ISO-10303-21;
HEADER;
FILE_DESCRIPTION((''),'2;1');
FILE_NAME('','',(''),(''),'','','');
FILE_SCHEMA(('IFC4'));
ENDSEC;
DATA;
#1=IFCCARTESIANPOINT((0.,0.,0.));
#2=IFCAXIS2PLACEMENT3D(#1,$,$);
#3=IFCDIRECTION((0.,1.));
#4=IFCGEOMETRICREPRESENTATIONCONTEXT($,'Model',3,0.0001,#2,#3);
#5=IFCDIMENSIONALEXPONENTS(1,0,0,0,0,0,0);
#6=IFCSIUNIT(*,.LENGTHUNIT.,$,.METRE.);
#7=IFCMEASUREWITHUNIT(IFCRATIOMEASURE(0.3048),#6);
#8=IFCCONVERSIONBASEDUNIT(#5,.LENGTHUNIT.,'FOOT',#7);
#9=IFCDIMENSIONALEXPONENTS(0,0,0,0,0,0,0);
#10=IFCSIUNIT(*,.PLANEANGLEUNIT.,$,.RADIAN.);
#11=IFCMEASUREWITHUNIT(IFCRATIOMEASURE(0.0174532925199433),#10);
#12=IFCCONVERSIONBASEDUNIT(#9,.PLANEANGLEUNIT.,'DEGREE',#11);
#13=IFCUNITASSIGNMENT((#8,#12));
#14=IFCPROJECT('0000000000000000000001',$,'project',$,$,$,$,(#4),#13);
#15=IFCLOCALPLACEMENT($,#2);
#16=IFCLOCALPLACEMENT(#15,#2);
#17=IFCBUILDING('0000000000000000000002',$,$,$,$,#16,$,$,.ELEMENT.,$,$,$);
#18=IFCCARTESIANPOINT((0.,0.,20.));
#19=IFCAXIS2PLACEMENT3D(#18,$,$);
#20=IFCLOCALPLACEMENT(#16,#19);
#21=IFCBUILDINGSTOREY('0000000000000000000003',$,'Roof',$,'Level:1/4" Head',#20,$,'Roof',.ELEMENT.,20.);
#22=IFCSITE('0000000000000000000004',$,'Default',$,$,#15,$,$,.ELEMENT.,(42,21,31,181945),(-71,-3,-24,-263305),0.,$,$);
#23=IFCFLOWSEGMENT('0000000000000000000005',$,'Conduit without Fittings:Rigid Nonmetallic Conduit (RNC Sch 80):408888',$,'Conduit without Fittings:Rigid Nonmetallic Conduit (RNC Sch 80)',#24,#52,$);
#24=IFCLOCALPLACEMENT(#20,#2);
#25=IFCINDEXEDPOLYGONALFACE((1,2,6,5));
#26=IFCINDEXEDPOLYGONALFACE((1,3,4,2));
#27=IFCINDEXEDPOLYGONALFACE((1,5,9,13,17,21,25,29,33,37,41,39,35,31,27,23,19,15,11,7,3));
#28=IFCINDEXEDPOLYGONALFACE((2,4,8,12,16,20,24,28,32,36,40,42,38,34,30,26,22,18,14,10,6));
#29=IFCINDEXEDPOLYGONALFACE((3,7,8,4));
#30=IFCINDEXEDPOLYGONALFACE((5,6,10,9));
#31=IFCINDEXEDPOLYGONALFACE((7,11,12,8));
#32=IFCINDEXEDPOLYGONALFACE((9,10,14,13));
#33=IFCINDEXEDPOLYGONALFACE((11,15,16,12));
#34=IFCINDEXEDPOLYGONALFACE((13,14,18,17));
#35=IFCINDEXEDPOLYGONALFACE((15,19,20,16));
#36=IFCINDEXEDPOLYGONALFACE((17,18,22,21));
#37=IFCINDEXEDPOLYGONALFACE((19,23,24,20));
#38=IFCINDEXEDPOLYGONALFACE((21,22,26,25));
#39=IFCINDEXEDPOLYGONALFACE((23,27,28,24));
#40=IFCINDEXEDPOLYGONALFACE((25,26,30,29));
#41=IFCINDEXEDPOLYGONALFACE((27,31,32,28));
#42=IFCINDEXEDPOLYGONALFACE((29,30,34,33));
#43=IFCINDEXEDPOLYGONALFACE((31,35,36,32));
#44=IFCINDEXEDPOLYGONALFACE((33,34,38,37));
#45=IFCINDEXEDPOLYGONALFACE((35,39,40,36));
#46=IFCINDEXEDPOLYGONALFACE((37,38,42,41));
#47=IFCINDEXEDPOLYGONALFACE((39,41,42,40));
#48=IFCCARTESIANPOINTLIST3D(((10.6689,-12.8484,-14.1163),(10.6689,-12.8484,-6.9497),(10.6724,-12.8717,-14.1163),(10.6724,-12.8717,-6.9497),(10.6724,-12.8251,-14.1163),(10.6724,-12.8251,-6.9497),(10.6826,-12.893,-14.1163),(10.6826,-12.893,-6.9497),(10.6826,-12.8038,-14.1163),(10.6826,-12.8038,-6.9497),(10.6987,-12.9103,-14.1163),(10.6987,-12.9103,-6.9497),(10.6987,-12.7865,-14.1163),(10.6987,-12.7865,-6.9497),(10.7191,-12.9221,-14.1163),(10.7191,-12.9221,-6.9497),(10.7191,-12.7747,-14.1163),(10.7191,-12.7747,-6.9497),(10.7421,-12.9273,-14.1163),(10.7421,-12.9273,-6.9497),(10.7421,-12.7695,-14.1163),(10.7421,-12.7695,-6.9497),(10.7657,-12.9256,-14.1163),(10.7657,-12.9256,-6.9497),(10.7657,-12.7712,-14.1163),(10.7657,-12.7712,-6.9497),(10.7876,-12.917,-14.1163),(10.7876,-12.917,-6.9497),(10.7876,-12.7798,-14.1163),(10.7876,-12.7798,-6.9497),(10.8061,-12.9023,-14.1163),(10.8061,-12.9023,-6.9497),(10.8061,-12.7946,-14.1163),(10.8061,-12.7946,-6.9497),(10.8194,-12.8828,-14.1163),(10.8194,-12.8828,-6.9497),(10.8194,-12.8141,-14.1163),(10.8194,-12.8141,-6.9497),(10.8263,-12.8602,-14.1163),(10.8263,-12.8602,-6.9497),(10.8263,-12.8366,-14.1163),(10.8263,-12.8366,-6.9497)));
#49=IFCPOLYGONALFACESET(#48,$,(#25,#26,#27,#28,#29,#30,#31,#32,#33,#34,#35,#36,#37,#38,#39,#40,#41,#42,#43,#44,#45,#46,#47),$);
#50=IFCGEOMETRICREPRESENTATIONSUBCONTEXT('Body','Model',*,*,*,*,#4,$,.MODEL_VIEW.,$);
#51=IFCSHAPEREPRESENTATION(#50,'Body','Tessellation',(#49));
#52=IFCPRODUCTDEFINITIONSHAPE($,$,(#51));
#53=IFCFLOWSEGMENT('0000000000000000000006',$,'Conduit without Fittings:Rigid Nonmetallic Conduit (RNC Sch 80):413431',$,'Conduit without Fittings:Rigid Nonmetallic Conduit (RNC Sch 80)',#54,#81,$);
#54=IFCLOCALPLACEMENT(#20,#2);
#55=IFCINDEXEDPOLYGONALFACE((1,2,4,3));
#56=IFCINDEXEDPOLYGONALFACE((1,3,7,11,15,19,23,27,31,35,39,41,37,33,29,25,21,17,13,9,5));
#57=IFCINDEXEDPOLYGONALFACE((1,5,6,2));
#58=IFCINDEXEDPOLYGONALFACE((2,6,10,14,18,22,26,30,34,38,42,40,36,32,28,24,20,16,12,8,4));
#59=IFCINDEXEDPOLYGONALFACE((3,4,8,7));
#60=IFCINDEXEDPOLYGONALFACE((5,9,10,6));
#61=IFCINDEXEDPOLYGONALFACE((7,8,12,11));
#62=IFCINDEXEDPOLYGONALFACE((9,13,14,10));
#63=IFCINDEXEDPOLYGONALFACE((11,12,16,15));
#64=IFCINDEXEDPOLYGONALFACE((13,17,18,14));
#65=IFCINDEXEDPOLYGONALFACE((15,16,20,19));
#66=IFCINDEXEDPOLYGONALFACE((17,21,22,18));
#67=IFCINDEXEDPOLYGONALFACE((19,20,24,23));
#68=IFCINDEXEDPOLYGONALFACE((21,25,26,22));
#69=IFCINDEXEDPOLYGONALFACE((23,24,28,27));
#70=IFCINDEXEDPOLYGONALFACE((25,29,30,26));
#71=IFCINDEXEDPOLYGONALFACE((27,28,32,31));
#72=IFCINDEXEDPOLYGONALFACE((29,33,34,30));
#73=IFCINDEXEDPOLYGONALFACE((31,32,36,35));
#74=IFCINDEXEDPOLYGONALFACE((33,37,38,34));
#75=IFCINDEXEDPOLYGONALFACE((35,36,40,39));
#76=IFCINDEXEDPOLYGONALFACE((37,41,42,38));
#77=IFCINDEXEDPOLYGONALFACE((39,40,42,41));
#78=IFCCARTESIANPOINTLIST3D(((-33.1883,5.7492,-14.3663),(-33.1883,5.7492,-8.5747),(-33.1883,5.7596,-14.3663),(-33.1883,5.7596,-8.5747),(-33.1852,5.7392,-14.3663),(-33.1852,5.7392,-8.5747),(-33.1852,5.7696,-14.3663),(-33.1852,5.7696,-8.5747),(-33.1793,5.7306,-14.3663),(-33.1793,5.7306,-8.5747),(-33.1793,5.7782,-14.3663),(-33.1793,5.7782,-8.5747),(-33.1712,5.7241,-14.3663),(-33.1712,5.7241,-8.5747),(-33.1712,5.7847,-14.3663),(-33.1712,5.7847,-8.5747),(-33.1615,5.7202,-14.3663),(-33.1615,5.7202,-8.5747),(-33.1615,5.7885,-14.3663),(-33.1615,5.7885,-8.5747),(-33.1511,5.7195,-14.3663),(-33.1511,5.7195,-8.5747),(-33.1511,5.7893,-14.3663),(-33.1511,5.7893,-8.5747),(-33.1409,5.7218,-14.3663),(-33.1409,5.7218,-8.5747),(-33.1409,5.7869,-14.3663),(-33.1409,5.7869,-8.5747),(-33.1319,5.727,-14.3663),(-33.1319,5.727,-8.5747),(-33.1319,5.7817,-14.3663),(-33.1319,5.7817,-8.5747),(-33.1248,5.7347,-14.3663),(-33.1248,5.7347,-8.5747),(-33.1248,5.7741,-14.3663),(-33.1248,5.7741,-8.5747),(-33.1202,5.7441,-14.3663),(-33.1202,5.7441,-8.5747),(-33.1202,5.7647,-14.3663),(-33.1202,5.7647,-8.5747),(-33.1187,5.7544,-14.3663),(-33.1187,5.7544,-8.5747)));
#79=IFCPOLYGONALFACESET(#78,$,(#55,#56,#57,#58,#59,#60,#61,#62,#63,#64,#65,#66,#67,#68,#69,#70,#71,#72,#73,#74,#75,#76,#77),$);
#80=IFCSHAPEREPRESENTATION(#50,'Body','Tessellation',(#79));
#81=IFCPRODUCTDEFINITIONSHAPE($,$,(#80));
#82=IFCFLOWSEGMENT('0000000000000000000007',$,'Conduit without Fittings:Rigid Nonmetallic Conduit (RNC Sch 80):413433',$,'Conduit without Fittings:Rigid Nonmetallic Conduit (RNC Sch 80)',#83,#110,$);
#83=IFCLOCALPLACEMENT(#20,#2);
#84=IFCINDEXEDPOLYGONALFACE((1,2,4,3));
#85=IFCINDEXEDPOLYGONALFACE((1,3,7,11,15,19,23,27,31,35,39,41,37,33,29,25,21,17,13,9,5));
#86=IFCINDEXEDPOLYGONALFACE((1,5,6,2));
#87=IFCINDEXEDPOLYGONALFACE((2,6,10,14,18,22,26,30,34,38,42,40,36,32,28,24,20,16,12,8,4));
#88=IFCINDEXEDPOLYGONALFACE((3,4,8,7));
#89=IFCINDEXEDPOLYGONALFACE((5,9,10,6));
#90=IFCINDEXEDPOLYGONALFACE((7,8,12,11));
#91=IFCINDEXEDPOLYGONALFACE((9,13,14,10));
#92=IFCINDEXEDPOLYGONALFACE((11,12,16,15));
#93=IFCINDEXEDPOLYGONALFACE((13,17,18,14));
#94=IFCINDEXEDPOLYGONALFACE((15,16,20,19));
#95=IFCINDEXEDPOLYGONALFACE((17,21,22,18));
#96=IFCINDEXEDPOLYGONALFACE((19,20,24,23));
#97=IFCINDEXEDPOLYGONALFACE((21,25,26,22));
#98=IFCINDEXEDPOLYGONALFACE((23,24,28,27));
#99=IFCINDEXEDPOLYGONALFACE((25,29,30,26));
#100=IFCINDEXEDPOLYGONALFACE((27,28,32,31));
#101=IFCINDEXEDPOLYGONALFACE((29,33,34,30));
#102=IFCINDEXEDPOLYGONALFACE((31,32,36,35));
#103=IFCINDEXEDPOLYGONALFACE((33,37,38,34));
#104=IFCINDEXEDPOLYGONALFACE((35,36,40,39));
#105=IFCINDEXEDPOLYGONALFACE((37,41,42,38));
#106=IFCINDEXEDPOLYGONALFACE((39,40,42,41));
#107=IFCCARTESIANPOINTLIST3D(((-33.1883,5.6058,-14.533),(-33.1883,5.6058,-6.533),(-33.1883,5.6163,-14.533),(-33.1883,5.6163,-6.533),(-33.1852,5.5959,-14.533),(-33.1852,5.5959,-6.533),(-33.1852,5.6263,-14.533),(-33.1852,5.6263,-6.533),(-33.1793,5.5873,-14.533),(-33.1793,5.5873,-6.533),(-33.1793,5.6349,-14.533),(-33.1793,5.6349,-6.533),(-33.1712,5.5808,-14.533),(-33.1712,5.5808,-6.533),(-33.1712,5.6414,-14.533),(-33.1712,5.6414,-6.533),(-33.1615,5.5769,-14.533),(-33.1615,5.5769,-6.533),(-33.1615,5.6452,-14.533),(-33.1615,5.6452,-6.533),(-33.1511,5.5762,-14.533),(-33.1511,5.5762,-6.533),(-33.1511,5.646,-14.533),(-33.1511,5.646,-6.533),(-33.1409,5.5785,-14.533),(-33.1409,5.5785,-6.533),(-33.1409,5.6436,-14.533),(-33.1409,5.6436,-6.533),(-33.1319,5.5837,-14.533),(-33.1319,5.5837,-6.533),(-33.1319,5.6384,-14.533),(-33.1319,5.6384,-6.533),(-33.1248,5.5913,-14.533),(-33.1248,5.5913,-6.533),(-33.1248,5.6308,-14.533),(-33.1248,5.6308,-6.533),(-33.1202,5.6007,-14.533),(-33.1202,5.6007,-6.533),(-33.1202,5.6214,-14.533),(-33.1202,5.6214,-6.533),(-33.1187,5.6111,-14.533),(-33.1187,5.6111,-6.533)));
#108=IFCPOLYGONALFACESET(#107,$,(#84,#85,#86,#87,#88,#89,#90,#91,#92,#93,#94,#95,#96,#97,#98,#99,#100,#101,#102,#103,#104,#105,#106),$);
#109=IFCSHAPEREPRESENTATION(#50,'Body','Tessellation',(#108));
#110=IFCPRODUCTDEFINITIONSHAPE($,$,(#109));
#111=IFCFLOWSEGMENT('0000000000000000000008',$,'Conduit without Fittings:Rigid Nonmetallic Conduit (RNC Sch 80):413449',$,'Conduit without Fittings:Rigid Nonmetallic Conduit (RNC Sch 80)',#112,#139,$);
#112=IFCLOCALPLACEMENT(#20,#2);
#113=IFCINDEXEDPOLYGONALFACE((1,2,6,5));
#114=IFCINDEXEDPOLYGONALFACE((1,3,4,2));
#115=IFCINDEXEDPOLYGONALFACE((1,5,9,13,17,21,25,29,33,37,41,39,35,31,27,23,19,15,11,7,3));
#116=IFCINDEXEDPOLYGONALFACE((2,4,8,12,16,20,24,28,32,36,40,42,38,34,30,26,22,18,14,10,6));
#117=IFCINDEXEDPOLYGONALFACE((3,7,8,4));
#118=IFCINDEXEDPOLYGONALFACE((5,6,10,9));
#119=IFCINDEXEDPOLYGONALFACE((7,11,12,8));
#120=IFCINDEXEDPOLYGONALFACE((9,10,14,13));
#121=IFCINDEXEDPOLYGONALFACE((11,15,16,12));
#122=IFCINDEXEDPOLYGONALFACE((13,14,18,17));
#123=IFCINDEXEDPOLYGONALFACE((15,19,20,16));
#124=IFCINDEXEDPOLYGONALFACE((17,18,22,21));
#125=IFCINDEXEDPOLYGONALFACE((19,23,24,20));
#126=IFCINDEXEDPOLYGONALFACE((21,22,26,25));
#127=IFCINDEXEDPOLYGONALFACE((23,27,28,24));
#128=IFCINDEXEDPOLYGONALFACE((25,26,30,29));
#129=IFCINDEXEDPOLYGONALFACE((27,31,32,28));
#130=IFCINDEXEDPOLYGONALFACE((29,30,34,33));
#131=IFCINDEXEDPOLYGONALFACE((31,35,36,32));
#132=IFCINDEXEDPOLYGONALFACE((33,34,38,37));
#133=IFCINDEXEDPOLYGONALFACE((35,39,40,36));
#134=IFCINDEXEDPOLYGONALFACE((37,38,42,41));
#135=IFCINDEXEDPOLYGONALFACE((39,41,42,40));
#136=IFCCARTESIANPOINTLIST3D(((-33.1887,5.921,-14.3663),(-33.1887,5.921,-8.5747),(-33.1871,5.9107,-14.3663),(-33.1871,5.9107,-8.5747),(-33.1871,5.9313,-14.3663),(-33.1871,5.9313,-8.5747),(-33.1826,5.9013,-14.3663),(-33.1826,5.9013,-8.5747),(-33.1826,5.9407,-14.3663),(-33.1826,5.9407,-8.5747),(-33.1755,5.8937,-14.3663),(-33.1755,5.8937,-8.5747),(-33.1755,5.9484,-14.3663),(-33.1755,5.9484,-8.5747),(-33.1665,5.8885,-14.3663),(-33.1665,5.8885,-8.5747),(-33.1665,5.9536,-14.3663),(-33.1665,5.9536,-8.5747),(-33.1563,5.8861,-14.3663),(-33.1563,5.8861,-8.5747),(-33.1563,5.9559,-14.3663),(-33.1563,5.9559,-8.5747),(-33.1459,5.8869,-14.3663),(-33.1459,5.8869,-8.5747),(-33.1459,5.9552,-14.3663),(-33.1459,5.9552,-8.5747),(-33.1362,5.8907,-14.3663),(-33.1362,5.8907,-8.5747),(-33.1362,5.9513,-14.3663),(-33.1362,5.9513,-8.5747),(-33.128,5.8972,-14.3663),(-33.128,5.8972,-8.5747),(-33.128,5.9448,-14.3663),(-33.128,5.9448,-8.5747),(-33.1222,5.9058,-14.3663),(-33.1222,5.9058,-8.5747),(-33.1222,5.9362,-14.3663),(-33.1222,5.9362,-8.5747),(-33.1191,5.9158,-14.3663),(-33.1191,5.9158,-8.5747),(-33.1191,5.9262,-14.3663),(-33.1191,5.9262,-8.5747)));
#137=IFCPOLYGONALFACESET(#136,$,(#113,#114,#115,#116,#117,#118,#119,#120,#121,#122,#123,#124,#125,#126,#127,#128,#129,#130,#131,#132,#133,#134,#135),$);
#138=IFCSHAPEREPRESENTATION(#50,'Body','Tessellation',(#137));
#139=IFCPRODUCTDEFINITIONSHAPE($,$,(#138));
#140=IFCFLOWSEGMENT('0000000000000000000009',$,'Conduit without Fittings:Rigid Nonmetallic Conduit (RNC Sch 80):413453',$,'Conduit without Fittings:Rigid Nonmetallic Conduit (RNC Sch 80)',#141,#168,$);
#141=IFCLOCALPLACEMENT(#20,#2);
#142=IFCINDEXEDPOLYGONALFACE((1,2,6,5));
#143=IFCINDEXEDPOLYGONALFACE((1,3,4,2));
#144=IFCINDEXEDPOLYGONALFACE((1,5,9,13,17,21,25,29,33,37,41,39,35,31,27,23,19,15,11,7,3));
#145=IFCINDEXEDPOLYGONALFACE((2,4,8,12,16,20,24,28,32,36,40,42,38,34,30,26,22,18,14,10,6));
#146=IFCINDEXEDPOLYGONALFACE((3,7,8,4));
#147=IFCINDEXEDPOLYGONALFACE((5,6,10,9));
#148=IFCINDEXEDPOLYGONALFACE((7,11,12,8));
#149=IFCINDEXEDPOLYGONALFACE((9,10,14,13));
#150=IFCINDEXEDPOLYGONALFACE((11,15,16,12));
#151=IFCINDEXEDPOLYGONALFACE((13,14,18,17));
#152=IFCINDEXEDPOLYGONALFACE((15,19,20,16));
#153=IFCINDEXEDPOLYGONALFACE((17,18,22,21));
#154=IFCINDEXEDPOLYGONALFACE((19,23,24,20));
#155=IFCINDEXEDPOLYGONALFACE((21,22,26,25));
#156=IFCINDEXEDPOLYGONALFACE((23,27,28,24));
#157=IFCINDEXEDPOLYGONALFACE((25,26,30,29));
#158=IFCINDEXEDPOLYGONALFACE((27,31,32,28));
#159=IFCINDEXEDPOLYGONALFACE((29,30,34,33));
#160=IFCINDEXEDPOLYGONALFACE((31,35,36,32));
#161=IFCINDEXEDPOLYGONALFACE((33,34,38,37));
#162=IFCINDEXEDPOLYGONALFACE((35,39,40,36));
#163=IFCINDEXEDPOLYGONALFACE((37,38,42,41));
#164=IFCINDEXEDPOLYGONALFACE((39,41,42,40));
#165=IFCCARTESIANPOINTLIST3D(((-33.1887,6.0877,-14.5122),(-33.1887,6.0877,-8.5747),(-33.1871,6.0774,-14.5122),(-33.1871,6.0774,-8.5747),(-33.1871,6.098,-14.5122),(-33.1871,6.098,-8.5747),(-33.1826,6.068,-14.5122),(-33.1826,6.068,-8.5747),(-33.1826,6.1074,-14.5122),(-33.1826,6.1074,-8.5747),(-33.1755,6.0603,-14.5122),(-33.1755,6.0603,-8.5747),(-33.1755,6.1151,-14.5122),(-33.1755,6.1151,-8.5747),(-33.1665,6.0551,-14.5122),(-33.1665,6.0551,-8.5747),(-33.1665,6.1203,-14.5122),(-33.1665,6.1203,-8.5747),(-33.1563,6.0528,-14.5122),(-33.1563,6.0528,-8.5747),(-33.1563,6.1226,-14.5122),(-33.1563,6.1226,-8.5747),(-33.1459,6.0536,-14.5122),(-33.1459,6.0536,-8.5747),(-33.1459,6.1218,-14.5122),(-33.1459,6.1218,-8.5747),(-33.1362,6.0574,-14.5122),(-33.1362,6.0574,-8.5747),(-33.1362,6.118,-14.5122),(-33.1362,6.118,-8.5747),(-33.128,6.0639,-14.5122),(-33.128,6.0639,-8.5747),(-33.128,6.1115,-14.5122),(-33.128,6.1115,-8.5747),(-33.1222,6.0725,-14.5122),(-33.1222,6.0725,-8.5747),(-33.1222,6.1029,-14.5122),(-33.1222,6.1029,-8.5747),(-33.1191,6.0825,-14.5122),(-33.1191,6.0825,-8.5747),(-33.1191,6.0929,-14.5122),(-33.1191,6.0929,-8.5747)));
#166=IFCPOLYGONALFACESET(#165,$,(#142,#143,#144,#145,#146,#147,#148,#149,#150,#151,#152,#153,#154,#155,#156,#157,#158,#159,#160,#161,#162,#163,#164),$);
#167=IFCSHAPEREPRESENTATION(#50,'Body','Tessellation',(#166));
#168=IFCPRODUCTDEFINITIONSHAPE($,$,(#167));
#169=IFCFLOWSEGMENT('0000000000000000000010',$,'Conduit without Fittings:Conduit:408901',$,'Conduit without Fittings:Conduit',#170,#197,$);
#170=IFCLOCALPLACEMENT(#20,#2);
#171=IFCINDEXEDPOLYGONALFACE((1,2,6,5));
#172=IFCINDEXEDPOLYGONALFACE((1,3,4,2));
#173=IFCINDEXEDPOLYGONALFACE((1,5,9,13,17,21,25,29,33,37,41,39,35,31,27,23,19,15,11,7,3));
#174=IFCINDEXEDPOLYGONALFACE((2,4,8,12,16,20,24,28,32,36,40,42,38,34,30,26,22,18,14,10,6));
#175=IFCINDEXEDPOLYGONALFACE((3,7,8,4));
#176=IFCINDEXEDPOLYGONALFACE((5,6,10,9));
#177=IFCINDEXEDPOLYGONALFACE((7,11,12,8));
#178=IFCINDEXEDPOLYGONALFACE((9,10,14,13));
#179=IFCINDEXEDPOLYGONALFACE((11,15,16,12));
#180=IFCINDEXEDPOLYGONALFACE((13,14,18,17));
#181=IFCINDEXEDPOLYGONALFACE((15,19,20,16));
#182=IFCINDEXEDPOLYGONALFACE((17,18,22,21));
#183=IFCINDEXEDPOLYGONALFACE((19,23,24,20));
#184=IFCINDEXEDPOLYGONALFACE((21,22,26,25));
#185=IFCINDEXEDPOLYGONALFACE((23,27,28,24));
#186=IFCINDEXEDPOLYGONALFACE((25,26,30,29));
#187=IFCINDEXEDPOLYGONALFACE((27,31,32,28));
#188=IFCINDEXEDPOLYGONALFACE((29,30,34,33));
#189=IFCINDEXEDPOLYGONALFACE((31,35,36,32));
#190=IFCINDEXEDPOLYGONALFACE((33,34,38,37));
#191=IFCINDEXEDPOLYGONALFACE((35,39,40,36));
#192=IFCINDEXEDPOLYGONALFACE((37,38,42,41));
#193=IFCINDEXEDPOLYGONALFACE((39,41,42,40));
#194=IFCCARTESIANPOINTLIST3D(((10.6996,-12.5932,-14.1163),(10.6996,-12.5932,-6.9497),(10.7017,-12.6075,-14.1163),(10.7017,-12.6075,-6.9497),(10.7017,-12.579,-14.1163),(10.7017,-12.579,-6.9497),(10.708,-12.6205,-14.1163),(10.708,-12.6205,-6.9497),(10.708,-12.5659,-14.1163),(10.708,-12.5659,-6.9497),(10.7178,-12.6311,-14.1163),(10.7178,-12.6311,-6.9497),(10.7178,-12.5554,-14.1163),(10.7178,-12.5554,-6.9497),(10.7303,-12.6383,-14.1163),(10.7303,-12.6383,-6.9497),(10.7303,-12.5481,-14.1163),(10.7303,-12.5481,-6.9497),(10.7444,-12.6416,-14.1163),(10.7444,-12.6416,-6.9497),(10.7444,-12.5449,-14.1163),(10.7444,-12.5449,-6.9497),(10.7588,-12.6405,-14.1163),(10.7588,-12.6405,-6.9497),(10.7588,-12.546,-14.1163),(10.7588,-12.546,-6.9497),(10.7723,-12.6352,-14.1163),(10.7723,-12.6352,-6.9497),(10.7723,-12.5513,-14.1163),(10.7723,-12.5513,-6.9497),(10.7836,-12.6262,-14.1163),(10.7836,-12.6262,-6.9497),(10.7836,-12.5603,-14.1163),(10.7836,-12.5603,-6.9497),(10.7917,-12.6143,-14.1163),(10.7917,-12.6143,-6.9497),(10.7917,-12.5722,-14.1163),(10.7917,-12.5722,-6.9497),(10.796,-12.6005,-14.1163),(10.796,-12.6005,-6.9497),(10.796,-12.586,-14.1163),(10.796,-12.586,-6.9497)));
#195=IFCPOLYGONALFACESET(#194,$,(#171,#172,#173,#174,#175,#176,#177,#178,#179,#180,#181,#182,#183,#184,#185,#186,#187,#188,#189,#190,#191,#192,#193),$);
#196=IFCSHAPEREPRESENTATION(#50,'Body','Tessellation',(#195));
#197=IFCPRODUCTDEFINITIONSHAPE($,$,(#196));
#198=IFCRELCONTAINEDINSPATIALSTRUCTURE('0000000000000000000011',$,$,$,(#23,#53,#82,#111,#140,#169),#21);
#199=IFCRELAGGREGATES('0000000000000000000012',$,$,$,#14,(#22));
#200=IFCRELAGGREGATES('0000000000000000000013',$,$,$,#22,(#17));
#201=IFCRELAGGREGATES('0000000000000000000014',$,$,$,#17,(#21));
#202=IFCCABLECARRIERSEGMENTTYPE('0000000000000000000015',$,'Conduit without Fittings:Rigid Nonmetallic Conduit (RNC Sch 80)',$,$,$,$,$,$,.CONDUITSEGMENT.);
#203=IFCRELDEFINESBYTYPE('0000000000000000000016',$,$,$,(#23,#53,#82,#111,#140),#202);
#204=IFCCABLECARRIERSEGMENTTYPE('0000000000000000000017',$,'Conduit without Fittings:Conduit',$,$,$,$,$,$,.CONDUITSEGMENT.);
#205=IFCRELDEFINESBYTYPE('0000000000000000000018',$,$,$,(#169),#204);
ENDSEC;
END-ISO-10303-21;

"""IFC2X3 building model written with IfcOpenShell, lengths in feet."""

from ifc_helpers import new_model, entity, si_unit, converted_unit, direction, frame, frame_2d, origin, origin_2d_with_axis, place, context, subcontext, project, spatial, circle, extrude, type_object, element, save


model = new_model("IFC2X3")

# Units and contexts
model_context = context("Model", 3, precision=0.0001, world=origin(), true_north=direction((0.0, 1.0)))
body_context = subcontext(model_context, "Body", "Model", "MODEL_VIEW")
ifc_project = project(units=[converted_unit("LENGTHUNIT", "FOOT", entity("IfcRatioMeasure", 0.3048), si_unit("LENGTHUNIT", "METRE"), dimensions=[1, 0, 0, 0, 0, 0, 0]), converted_unit("PLANEANGLEUNIT", "DEGREE", entity("IfcRatioMeasure", 0.0174532925199433), si_unit("PLANEANGLEUNIT", "RADIAN"), dimensions=[0, 0, 0, 0, 0, 0, 0])], contexts=[model_context])

# Site, building, storey
site_placement = place(None, origin())
site = spatial("IfcSite", under=ifc_project, at=site_placement, Name="Default", CompositionType="ELEMENT", RefLatitude=(42, 21, 31, 181945), RefLongitude=(-71, -3, -24, -263305), RefElevation=0.0)
building_placement = place(site_placement, origin())
building = spatial("IfcBuilding", under=site, at=building_placement, CompositionType="ELEMENT")
storey_placement = place(building_placement, frame((0.0, 0.0, 20.0)))
storey = spatial("IfcBuildingStorey", under=building, at=storey_placement, Name="Roof", ObjectType="Level:1/4\" Head", LongName="Roof", CompositionType="ELEMENT", Elevation=20.0)

# Flow segments
cable_carrier_segment_type_1 = type_object("IfcCableCarrierSegmentType", Name="Conduit without Fittings:Rigid Nonmetallic Conduit (RNC Sch 80)", PredefinedType="CONDUITSEGMENT")
flow_segment_1_placement = place(storey_placement, origin())
element("IfcFlowSegment", 1, at=flow_segment_1_placement, inside=storey, type_object=cable_carrier_segment_type_1, Name="Conduit without Fittings:Rigid Nonmetallic Conduit (RNC Sch 80):408888", ObjectType="Conduit without Fittings:Rigid Nonmetallic Conduit (RNC Sch 80)", context=body_context, shape_type="SweptSolid", body=[
    extrude(circle(Radius=0.0792, at=origin_2d_with_axis()), frame((10.748, -12.8484, -14.1163), z_axis=(0.0, 0.0, 1.0), x_axis=(-1.0, 0.0, 0.0)), (0.0, 0.0, 1.0), 7.1667),
])
flow_segment_2_placement = place(storey_placement, origin())
element("IfcFlowSegment", 2, at=flow_segment_2_placement, inside=storey, type_object=cable_carrier_segment_type_1, Name="Conduit without Fittings:Rigid Nonmetallic Conduit (RNC Sch 80):413431", ObjectType="Conduit without Fittings:Rigid Nonmetallic Conduit (RNC Sch 80)", context=body_context, shape_type="SweptSolid", body=[
    extrude(circle(Radius=0.035, at=frame_2d((0.0, 0.0), x_axis=(1.0, 0.0))), frame((-33.1537, 5.7544, -14.3663)), (0.0, 0.0, 1.0), 5.7917),
])
flow_segment_3_placement = place(storey_placement, origin())
element("IfcFlowSegment", 3, at=flow_segment_3_placement, inside=storey, type_object=cable_carrier_segment_type_1, Name="Conduit without Fittings:Rigid Nonmetallic Conduit (RNC Sch 80):413433", ObjectType="Conduit without Fittings:Rigid Nonmetallic Conduit (RNC Sch 80)", context=body_context, shape_type="SweptSolid", body=[
    extrude(circle(Radius=0.035, at=frame_2d((0.0, 0.0), x_axis=(1.0, 0.0))), frame((-33.1537, 5.6111, -14.533)), (0.0, 0.0, 1.0), 8.0),
])
flow_segment_4_placement = place(storey_placement, origin())
element("IfcFlowSegment", 4, at=flow_segment_4_placement, inside=storey, type_object=cable_carrier_segment_type_1, Name="Conduit without Fittings:Rigid Nonmetallic Conduit (RNC Sch 80):413449", ObjectType="Conduit without Fittings:Rigid Nonmetallic Conduit (RNC Sch 80)", context=body_context, shape_type="SweptSolid", body=[
    extrude(circle(Radius=0.035, at=origin_2d_with_axis()), frame((-33.1537, 5.921, -14.3663), z_axis=(0.0, 0.0, 1.0), x_axis=(-1.0, 0.0, 0.0)), (0.0, 0.0, 1.0), 5.7917),
])
flow_segment_5_placement = place(storey_placement, origin())
element("IfcFlowSegment", 5, at=flow_segment_5_placement, inside=storey, type_object=cable_carrier_segment_type_1, Name="Conduit without Fittings:Rigid Nonmetallic Conduit (RNC Sch 80):413453", ObjectType="Conduit without Fittings:Rigid Nonmetallic Conduit (RNC Sch 80)", context=body_context, shape_type="SweptSolid", body=[
    extrude(circle(Radius=0.035, at=origin_2d_with_axis()), frame((-33.1537, 6.0877, -14.5122), z_axis=(0.0, 0.0, 1.0), x_axis=(-1.0, 0.0, 0.0)), (0.0, 0.0, 1.0), 5.9375),
])
cable_carrier_segment_type_2 = type_object("IfcCableCarrierSegmentType", Name="Conduit without Fittings:Conduit", PredefinedType="CONDUITSEGMENT")
flow_segment_6_placement = place(storey_placement, origin())
element("IfcFlowSegment", 6, at=flow_segment_6_placement, inside=storey, type_object=cable_carrier_segment_type_2, Name="Conduit without Fittings:Conduit:408901", ObjectType="Conduit without Fittings:Conduit", context=body_context, shape_type="SweptSolid", body=[
    extrude(circle(Radius=0.0485, at=origin_2d_with_axis()), frame((10.748, -12.5932, -14.1163), z_axis=(0.0, 0.0, 1.0), x_axis=(-1.0, 0.0, 0.0)), (0.0, 0.0, 1.0), 7.1667),
])

save(model, "model.ifc")
